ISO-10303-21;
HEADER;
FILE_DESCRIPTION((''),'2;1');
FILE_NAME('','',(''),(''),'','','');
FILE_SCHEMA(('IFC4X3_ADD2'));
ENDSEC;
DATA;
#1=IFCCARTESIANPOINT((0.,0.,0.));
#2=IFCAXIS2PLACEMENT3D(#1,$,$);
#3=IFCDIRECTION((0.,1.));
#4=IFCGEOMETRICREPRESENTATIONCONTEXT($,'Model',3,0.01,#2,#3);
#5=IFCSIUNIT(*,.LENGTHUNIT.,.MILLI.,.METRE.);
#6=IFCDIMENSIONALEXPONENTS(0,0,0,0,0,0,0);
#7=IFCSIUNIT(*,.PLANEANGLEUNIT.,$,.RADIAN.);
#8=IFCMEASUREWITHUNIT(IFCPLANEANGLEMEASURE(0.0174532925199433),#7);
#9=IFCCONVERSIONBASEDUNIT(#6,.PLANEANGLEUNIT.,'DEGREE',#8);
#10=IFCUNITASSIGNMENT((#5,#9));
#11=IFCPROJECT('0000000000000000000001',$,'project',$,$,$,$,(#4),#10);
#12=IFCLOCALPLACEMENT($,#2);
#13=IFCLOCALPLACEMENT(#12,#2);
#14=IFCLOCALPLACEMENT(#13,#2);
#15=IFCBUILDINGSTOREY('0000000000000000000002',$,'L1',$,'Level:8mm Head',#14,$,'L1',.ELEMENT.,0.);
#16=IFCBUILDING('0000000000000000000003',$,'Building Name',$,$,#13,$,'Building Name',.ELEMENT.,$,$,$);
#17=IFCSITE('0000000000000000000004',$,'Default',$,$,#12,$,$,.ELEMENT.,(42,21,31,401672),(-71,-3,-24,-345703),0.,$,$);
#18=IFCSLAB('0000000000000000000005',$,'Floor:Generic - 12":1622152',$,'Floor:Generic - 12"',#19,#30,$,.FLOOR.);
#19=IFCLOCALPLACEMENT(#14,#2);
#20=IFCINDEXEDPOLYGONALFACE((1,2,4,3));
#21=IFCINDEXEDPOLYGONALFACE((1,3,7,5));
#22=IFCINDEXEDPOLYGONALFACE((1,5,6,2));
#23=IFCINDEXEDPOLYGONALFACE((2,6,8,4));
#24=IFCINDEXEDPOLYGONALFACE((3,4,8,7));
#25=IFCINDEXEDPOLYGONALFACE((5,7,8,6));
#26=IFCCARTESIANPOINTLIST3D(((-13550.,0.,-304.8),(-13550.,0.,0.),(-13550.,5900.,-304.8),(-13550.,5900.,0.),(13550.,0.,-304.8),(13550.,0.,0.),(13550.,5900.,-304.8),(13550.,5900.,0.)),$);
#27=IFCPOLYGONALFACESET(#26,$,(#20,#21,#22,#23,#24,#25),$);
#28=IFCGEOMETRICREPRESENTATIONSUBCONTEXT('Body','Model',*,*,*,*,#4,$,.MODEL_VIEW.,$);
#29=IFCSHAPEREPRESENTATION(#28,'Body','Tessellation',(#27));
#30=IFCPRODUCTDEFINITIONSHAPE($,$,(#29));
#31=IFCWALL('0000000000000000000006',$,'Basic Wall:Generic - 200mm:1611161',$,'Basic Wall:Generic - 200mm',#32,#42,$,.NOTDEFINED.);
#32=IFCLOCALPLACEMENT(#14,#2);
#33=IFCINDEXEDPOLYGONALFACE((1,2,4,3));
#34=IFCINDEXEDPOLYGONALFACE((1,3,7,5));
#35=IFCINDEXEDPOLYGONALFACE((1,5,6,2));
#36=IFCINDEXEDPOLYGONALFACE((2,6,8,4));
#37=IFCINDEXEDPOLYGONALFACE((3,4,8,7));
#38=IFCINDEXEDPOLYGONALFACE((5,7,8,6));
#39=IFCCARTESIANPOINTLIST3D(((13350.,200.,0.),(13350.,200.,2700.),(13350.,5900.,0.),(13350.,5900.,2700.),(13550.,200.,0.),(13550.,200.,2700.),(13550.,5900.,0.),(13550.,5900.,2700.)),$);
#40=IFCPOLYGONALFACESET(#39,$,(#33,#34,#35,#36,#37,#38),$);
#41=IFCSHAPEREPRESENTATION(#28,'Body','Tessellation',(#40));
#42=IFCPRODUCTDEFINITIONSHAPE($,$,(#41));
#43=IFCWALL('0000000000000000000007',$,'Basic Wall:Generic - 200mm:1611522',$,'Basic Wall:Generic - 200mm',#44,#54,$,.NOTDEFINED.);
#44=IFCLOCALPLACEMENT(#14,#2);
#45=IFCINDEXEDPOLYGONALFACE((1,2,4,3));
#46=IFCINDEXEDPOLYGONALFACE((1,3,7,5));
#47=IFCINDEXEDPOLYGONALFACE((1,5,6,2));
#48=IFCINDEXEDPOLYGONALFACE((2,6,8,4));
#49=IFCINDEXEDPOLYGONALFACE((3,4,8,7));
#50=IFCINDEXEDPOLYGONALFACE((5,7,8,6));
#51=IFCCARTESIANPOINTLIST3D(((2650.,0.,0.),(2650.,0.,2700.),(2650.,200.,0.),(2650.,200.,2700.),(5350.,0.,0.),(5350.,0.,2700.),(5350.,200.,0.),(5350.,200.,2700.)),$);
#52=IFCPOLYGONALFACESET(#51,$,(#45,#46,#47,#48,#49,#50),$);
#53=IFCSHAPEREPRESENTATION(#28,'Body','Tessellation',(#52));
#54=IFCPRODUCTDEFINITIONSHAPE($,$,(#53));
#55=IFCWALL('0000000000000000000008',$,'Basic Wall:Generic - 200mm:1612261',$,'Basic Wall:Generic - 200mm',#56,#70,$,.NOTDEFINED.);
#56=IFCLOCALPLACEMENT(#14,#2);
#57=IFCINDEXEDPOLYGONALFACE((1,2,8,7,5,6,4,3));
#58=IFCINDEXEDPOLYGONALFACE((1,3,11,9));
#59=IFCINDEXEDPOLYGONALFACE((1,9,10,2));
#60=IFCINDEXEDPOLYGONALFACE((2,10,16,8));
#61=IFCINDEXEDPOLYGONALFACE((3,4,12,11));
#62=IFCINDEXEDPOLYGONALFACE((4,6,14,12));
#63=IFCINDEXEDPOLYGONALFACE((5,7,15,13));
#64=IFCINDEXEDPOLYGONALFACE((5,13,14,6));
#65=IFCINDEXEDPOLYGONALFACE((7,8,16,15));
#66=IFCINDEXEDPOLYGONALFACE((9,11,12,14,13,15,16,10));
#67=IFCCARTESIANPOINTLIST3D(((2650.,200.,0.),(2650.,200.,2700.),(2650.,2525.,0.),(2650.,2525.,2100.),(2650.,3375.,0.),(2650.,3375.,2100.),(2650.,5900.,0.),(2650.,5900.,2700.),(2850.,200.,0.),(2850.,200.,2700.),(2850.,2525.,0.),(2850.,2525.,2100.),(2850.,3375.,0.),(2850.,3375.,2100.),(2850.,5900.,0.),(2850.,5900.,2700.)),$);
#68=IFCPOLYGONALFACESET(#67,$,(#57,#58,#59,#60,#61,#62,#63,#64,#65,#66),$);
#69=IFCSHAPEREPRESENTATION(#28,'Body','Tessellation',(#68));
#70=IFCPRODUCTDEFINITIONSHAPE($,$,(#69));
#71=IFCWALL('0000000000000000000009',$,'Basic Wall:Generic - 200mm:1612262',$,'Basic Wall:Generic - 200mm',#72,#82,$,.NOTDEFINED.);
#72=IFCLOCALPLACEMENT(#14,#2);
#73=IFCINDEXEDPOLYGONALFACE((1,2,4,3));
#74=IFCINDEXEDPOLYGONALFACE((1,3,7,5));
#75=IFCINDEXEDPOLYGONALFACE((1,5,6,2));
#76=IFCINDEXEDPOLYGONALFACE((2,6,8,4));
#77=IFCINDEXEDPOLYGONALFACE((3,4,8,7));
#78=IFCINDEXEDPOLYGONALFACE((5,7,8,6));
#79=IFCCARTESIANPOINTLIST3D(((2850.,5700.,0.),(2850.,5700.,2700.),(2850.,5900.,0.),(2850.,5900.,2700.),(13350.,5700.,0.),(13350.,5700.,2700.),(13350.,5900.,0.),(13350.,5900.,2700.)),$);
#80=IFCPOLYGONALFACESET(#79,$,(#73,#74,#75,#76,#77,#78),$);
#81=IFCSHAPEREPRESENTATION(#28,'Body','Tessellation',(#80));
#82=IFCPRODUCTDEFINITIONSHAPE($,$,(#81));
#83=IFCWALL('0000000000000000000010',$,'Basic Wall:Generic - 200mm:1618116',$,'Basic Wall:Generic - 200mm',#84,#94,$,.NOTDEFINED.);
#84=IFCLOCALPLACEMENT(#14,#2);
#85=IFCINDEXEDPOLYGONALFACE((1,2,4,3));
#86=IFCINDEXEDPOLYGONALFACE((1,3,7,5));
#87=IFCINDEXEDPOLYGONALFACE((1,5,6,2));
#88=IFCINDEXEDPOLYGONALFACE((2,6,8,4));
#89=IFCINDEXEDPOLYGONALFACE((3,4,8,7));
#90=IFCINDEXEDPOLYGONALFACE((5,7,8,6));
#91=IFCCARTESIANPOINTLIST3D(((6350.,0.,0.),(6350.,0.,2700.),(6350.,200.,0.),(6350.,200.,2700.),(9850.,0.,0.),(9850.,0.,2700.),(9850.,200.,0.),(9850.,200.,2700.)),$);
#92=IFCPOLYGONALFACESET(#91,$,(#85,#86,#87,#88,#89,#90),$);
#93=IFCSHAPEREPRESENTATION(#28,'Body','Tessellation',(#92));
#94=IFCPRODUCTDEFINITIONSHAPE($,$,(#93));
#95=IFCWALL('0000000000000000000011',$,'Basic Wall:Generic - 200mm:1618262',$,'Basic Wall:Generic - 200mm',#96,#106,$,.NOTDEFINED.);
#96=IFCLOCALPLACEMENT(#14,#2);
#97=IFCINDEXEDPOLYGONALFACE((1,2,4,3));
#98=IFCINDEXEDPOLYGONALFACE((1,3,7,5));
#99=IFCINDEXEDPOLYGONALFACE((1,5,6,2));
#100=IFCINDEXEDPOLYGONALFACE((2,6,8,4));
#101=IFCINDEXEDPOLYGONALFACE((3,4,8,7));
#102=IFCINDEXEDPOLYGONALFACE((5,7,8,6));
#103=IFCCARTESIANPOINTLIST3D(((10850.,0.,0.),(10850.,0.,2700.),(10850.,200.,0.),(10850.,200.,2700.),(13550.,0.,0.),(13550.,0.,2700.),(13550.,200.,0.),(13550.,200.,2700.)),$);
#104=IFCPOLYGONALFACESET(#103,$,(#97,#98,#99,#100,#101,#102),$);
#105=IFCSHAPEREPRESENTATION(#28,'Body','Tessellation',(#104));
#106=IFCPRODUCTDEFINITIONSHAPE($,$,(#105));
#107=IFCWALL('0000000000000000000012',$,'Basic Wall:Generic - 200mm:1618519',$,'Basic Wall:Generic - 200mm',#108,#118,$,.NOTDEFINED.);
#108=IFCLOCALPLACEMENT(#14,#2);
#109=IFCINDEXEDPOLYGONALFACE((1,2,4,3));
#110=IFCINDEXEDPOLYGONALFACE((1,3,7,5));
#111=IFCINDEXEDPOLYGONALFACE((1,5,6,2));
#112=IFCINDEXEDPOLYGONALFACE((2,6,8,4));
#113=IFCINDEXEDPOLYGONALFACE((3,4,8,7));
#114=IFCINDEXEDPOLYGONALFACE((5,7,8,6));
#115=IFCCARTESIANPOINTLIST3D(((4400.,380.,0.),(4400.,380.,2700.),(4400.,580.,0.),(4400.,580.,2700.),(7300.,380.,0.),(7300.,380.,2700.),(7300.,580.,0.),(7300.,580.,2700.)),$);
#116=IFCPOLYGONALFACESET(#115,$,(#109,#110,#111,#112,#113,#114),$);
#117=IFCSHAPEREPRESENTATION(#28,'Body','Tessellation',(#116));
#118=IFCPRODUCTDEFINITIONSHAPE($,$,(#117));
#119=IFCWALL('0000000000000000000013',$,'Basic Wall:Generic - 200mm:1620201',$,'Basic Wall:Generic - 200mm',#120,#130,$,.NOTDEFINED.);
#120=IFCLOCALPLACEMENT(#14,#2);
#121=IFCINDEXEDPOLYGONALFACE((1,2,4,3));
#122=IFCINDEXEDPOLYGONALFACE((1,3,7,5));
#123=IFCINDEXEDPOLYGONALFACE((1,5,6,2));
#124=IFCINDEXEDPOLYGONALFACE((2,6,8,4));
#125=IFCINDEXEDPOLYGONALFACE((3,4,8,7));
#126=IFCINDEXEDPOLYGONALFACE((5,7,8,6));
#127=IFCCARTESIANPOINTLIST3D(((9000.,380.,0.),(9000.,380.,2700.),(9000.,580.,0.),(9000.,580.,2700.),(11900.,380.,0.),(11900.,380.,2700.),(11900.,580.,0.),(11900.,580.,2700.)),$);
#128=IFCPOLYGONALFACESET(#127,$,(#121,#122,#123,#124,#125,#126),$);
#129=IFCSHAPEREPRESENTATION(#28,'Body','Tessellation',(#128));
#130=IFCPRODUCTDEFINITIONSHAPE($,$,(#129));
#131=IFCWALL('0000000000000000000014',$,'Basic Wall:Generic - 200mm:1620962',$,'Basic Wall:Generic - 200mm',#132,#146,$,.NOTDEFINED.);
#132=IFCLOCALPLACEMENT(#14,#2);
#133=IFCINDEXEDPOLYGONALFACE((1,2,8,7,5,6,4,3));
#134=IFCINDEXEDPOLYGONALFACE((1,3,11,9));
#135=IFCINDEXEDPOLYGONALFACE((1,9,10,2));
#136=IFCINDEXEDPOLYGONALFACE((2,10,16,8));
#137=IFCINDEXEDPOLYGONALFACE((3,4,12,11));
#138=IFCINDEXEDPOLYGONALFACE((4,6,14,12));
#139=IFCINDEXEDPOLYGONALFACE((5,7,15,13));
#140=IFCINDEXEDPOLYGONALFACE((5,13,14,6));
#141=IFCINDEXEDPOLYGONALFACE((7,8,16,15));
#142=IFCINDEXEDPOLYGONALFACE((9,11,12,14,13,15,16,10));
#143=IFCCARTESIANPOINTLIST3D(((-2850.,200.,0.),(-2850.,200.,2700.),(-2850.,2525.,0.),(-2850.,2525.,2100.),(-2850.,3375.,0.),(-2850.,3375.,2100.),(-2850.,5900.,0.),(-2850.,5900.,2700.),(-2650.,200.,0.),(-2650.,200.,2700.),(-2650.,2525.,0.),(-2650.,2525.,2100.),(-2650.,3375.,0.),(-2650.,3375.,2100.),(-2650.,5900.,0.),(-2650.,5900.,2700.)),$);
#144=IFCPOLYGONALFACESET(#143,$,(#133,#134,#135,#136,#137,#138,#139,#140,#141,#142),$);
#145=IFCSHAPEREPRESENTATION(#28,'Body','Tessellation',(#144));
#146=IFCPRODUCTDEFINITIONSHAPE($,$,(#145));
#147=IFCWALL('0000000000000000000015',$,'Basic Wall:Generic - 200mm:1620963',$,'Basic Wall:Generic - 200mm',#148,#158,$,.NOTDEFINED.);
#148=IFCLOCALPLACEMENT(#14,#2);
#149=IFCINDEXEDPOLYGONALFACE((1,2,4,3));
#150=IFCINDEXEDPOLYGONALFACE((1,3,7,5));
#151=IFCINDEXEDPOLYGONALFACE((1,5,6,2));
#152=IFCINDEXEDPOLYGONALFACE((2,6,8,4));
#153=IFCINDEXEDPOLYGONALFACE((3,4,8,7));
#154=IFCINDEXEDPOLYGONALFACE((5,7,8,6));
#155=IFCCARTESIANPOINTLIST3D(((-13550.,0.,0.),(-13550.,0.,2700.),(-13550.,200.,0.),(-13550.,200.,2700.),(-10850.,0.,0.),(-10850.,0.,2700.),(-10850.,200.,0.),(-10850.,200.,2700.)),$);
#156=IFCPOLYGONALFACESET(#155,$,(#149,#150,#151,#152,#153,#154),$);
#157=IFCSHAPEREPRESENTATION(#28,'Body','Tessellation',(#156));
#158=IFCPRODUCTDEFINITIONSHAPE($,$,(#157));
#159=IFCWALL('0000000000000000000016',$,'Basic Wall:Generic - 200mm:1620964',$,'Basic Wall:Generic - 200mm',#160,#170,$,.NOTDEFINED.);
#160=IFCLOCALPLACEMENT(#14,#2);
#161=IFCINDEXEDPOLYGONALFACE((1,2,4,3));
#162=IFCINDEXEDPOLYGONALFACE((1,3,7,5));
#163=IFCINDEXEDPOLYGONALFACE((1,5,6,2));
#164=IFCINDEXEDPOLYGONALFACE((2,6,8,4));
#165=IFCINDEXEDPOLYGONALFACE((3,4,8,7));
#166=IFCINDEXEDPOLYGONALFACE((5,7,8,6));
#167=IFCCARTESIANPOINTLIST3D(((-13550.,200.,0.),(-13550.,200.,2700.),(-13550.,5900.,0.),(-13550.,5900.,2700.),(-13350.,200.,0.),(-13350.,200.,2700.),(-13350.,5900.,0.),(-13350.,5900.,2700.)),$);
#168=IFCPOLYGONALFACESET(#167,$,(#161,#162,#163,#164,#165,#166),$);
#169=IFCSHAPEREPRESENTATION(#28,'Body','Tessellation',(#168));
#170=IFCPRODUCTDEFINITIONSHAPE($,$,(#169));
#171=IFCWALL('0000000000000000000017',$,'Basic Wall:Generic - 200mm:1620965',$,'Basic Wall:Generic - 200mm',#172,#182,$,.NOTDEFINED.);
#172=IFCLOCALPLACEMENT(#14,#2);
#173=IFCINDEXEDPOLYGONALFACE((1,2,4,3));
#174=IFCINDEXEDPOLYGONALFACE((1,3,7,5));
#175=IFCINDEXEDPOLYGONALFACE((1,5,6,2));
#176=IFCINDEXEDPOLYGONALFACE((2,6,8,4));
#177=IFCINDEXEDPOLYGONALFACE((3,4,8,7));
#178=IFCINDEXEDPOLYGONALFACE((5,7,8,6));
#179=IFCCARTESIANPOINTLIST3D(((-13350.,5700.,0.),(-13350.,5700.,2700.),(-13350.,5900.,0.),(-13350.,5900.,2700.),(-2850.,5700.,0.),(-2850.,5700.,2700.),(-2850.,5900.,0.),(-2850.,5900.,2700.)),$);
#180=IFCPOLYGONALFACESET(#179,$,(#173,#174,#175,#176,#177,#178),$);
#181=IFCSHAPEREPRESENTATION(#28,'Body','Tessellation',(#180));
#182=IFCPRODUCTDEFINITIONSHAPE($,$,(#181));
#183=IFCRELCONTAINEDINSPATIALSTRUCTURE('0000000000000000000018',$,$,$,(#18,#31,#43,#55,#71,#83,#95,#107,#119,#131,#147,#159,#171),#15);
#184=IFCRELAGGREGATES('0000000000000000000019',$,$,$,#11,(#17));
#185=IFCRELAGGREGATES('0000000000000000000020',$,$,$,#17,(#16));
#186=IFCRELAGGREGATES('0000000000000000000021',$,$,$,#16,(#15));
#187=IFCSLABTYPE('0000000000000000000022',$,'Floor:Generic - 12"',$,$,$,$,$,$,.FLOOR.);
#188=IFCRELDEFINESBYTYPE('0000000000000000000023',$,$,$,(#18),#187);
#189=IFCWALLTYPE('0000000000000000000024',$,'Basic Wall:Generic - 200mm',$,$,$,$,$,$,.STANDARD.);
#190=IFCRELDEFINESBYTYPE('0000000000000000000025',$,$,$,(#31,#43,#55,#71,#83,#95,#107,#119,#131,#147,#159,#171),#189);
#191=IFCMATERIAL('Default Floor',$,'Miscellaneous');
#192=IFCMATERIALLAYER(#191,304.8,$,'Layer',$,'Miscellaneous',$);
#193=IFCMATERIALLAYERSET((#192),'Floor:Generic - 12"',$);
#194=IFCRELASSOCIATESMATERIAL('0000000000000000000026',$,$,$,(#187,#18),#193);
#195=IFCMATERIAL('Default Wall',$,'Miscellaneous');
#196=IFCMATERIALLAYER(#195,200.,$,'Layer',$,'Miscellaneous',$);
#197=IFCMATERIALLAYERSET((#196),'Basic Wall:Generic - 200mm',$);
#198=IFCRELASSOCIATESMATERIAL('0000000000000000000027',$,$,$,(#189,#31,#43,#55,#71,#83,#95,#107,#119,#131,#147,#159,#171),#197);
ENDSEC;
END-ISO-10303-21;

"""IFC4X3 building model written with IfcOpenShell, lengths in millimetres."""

from ifc_helpers import new_model, entity, si_unit, converted_unit, direction, frame, frame_2d, origin, origin_2d_with_axis, place, context, subcontext, project, spatial, rectangle, extrude, material, layer, layer_set, layer_usage, type_object, element, save


model = new_model("IFC4X3")

# Units and contexts
model_context = context("Model", 3, precision=0.01, world=origin(), true_north=direction((0.0, 1.0)))
body_context = subcontext(model_context, "Body", "Model", "MODEL_VIEW")
ifc_project = project(units=[si_unit("LENGTHUNIT", "METRE", prefix="MILLI"), converted_unit("PLANEANGLEUNIT", "DEGREE", entity("IfcPlaneAngleMeasure", 0.0174532925199433), si_unit("PLANEANGLEUNIT", "RADIAN"), dimensions=[0, 0, 0, 0, 0, 0, 0])], contexts=[model_context])

# Site, building, storey
site_placement = place(None, origin())
site = spatial("IfcSite", under=ifc_project, at=site_placement, Name="Default", CompositionType="ELEMENT", RefLatitude=(42, 21, 31, 401672), RefLongitude=(-71, -3, -24, -345703), RefElevation=0.0)
building_placement = place(site_placement, origin())
building = spatial("IfcBuilding", under=site, at=building_placement, Name="Building Name", LongName="Building Name", CompositionType="ELEMENT")
storey_placement = place(building_placement, origin())
storey = spatial("IfcBuildingStorey", under=building, at=storey_placement, Name="L1", ObjectType="Level:8mm Head", LongName="L1", CompositionType="ELEMENT", Elevation=0.0)

# Slab
ifc_material_1 = material(Name="Default Floor", Category="Miscellaneous")
ifc_layer_1 = layer(ifc_material_1, 304.8, Name="Layer", Category="Miscellaneous")
ifc_layer_set_1 = layer_set([ifc_layer_1], Name="Floor:Generic - 12\"")
ifc_layer_usage = layer_usage(ifc_layer_set_1, "AXIS3", "POSITIVE", 0.0)
slab_type = type_object("IfcSlabType", Name="Floor:Generic - 12\"", PredefinedType="FLOOR", material=ifc_layer_set_1)
slab_placement = place(storey_placement, origin())
element("IfcSlab", 1, at=slab_placement, inside=storey, type_object=slab_type, material=ifc_layer_usage, Name="Floor:Generic - 12\":1622152", ObjectType="Floor:Generic - 12\"", PredefinedType="FLOOR", context=body_context, shape_type="SweptSolid", body=[
    extrude(rectangle(XDim=5900.0, YDim=27100.0, at=origin_2d_with_axis()), frame((0.0, 2950.0, 0.0), z_axis=(0.0, 0.0, -1.0), x_axis=(0.0, 1.0, 0.0)), (0.0, 0.0, 1.0), 304.8),
])

# Walls
ifc_material_2 = material(Name="Default Wall", Category="Miscellaneous")
ifc_layer_2 = layer(ifc_material_2, 200.0, Name="Layer", Category="Miscellaneous")
ifc_layer_set_2 = layer_set([ifc_layer_2], Name="Basic Wall:Generic - 200mm")
wall_type = type_object("IfcWallType", Name="Basic Wall:Generic - 200mm", PredefinedType="STANDARD", material=ifc_layer_set_2)
wall_1_placement = place(storey_placement, frame((13450.0, 200.0, 0.0), z_axis=(0.0, 0.0, 1.0), x_axis=(0.0, 1.0, 0.0)))
element("IfcWall", 2, at=wall_1_placement, inside=storey, type_object=wall_type, material=ifc_layer_set_2, Name="Basic Wall:Generic - 200mm:1611161", ObjectType="Basic Wall:Generic - 200mm", PredefinedType="NOTDEFINED", context=body_context, shape_type="SweptSolid", body=[
    extrude(rectangle(XDim=5700.0, YDim=200.0, at=frame_2d((2850.0, 0.0), x_axis=(-1.0, 0.0))), origin(), (0.0, 0.0, 1.0), 2700.0),
])
wall_2_placement = place(storey_placement, frame((2650.0, 100.0, 0.0)))
element("IfcWall", 3, at=wall_2_placement, inside=storey, type_object=wall_type, material=ifc_layer_set_2, Name="Basic Wall:Generic - 200mm:1611522", ObjectType="Basic Wall:Generic - 200mm", PredefinedType="NOTDEFINED", context=body_context, shape_type="SweptSolid", body=[
    extrude(rectangle(XDim=2700.0, YDim=200.0, at=frame_2d((1350.0, 0.0), x_axis=(-1.0, 0.0))), origin(), (0.0, 0.0, 1.0), 2700.0),
])

# Wall, opening
wall_3_placement = place(storey_placement, frame((2750.0, 5900.0, 0.0), z_axis=(0.0, 0.0, 1.0), x_axis=(0.0, -1.0, 0.0)))
wall_3 = element("IfcWall", 4, at=wall_3_placement, inside=storey, type_object=wall_type, material=ifc_layer_set_2, Name="Basic Wall:Generic - 200mm:1612261", ObjectType="Basic Wall:Generic - 200mm", PredefinedType="NOTDEFINED", context=body_context, shape_type="SweptSolid", body=[
    extrude(rectangle(XDim=5700.0, YDim=200.0, at=frame_2d((2850.0, 0.0), x_axis=(-1.0, 0.0))), origin(), (0.0, 0.0, 1.0), 2700.0),
])
opening_1_placement = place(wall_3_placement, frame((2525.0, -100.0, 0.0)))
element("IfcOpeningElement", 5, at=opening_1_placement, cuts=wall_3, PredefinedType="OPENING", context=body_context, shape_type="SweptSolid", body=[
    extrude(rectangle(XDim=2100.0, YDim=850.0, at=frame_2d((1050.0, 425.0), x_axis=(1.0, 0.0))), frame((0.0, 0.0, 0.0), z_axis=(0.0, 1.0, 0.0), x_axis=(0.0, 0.0, 1.0)), (0.0, 0.0, 1.0), 200.0),
])

# Walls
wall_4_placement = place(storey_placement, frame((13350.0, 5800.0, 0.0), z_axis=(0.0, 0.0, 1.0), x_axis=(-1.0, 0.0, 0.0)))
element("IfcWall", 6, at=wall_4_placement, inside=storey, type_object=wall_type, material=ifc_layer_set_2, Name="Basic Wall:Generic - 200mm:1612262", ObjectType="Basic Wall:Generic - 200mm", PredefinedType="NOTDEFINED", context=body_context, shape_type="SweptSolid", body=[
    extrude(rectangle(XDim=10500.0, YDim=200.0, at=frame_2d((5250.0, 0.0), x_axis=(-1.0, 0.0))), origin(), (0.0, 0.0, 1.0), 2700.0),
])
wall_5_placement = place(storey_placement, frame((6350.0, 100.0, 0.0)))
element("IfcWall", 7, at=wall_5_placement, inside=storey, type_object=wall_type, material=ifc_layer_set_2, Name="Basic Wall:Generic - 200mm:1618116", ObjectType="Basic Wall:Generic - 200mm", PredefinedType="NOTDEFINED", context=body_context, shape_type="SweptSolid", body=[
    extrude(rectangle(XDim=3500.0, YDim=200.0, at=frame_2d((1750.0, 0.0), x_axis=(-1.0, 0.0))), origin(), (0.0, 0.0, 1.0), 2700.0),
])
wall_6_placement = place(storey_placement, frame((10850.0, 100.0, 0.0)))
element("IfcWall", 8, at=wall_6_placement, inside=storey, type_object=wall_type, material=ifc_layer_set_2, Name="Basic Wall:Generic - 200mm:1618262", ObjectType="Basic Wall:Generic - 200mm", PredefinedType="NOTDEFINED", context=body_context, shape_type="SweptSolid", body=[
    extrude(rectangle(XDim=2700.0, YDim=200.0, at=frame_2d((1350.0, 0.0), x_axis=(-1.0, 0.0))), origin(), (0.0, 0.0, 1.0), 2700.0),
])
for number, where, z_axis, x_axis, name in (
    (9, (7300.0, 480.0, 0.0), (0.0, 0.0, 1.0), (-1.0, 0.0, 0.0), "Basic Wall:Generic - 200mm:1618519"),
    (10, (11900.0, 480.0, 0.0), (0.0, 0.0, 1.0), (-1.0, 0.0, 0.0), "Basic Wall:Generic - 200mm:1620201"),
):
    element("IfcWall", number, at=place(storey_placement, frame(where, z_axis=z_axis, x_axis=x_axis)), inside=storey, type_object=wall_type, material=ifc_layer_set_2, Name=name, ObjectType="Basic Wall:Generic - 200mm", PredefinedType="NOTDEFINED", context=body_context, shape_type="SweptSolid", body=[
        extrude(rectangle(XDim=2900.0, YDim=200.0, at=frame_2d((1450.0, 0.0), x_axis=(-1.0, 0.0))), origin(), (0.0, 0.0, 1.0), 2700.0),
    ])

# Wall, opening
wall_7_placement = place(storey_placement, frame((-2750.0, 200.0, 0.0), z_axis=(0.0, 0.0, 1.0), x_axis=(0.0, 1.0, 0.0)))
wall_7 = element("IfcWall", 11, at=wall_7_placement, inside=storey, type_object=wall_type, material=ifc_layer_set_2, Name="Basic Wall:Generic - 200mm:1620962", ObjectType="Basic Wall:Generic - 200mm", PredefinedType="NOTDEFINED", context=body_context, shape_type="SweptSolid", body=[
    extrude(rectangle(XDim=5700.0, YDim=200.0, at=frame_2d((2850.0, 0.0), x_axis=(-1.0, 0.0))), origin(), (0.0, 0.0, 1.0), 2700.0),
])
opening_2_placement = place(wall_7_placement, frame((2325.0, -100.0, 0.0)))
element("IfcOpeningElement", 12, at=opening_2_placement, cuts=wall_7, PredefinedType="OPENING", context=body_context, shape_type="SweptSolid", body=[
    extrude(rectangle(XDim=2100.0, YDim=850.0, at=frame_2d((1050.0, 425.0), x_axis=(1.0, 0.0))), frame((0.0, 0.0, 0.0), z_axis=(0.0, 1.0, 0.0), x_axis=(0.0, 0.0, 1.0)), (0.0, 0.0, 1.0), 200.0),
])

# Walls
wall_8_placement = place(storey_placement, frame((-13550.0, 100.0, 0.0)))
element("IfcWall", 13, at=wall_8_placement, inside=storey, type_object=wall_type, material=ifc_layer_set_2, Name="Basic Wall:Generic - 200mm:1620963", ObjectType="Basic Wall:Generic - 200mm", PredefinedType="NOTDEFINED", context=body_context, shape_type="SweptSolid", body=[
    extrude(rectangle(XDim=2700.0, YDim=200.0, at=frame_2d((1350.0, 0.0), x_axis=(-1.0, 0.0))), origin(), (0.0, 0.0, 1.0), 2700.0),
])
wall_9_placement = place(storey_placement, frame((-13450.0, 5900.0, 0.0), z_axis=(0.0, 0.0, 1.0), x_axis=(0.0, -1.0, 0.0)))
element("IfcWall", 14, at=wall_9_placement, inside=storey, type_object=wall_type, material=ifc_layer_set_2, Name="Basic Wall:Generic - 200mm:1620964", ObjectType="Basic Wall:Generic - 200mm", PredefinedType="NOTDEFINED", context=body_context, shape_type="SweptSolid", body=[
    extrude(rectangle(XDim=5700.0, YDim=200.0, at=frame_2d((2850.0, 0.0), x_axis=(-1.0, 0.0))), origin(), (0.0, 0.0, 1.0), 2700.0),
])
wall_10_placement = place(storey_placement, frame((-2850.0, 5800.0, 0.0), z_axis=(0.0, 0.0, 1.0), x_axis=(-1.0, 0.0, 0.0)))
element("IfcWall", 15, at=wall_10_placement, inside=storey, type_object=wall_type, material=ifc_layer_set_2, Name="Basic Wall:Generic - 200mm:1620965", ObjectType="Basic Wall:Generic - 200mm", PredefinedType="NOTDEFINED", context=body_context, shape_type="SweptSolid", body=[
    extrude(rectangle(XDim=10500.0, YDim=200.0, at=frame_2d((5250.0, 0.0), x_axis=(-1.0, 0.0))), origin(), (0.0, 0.0, 1.0), 2700.0),
])

save(model, "model.ifc")
